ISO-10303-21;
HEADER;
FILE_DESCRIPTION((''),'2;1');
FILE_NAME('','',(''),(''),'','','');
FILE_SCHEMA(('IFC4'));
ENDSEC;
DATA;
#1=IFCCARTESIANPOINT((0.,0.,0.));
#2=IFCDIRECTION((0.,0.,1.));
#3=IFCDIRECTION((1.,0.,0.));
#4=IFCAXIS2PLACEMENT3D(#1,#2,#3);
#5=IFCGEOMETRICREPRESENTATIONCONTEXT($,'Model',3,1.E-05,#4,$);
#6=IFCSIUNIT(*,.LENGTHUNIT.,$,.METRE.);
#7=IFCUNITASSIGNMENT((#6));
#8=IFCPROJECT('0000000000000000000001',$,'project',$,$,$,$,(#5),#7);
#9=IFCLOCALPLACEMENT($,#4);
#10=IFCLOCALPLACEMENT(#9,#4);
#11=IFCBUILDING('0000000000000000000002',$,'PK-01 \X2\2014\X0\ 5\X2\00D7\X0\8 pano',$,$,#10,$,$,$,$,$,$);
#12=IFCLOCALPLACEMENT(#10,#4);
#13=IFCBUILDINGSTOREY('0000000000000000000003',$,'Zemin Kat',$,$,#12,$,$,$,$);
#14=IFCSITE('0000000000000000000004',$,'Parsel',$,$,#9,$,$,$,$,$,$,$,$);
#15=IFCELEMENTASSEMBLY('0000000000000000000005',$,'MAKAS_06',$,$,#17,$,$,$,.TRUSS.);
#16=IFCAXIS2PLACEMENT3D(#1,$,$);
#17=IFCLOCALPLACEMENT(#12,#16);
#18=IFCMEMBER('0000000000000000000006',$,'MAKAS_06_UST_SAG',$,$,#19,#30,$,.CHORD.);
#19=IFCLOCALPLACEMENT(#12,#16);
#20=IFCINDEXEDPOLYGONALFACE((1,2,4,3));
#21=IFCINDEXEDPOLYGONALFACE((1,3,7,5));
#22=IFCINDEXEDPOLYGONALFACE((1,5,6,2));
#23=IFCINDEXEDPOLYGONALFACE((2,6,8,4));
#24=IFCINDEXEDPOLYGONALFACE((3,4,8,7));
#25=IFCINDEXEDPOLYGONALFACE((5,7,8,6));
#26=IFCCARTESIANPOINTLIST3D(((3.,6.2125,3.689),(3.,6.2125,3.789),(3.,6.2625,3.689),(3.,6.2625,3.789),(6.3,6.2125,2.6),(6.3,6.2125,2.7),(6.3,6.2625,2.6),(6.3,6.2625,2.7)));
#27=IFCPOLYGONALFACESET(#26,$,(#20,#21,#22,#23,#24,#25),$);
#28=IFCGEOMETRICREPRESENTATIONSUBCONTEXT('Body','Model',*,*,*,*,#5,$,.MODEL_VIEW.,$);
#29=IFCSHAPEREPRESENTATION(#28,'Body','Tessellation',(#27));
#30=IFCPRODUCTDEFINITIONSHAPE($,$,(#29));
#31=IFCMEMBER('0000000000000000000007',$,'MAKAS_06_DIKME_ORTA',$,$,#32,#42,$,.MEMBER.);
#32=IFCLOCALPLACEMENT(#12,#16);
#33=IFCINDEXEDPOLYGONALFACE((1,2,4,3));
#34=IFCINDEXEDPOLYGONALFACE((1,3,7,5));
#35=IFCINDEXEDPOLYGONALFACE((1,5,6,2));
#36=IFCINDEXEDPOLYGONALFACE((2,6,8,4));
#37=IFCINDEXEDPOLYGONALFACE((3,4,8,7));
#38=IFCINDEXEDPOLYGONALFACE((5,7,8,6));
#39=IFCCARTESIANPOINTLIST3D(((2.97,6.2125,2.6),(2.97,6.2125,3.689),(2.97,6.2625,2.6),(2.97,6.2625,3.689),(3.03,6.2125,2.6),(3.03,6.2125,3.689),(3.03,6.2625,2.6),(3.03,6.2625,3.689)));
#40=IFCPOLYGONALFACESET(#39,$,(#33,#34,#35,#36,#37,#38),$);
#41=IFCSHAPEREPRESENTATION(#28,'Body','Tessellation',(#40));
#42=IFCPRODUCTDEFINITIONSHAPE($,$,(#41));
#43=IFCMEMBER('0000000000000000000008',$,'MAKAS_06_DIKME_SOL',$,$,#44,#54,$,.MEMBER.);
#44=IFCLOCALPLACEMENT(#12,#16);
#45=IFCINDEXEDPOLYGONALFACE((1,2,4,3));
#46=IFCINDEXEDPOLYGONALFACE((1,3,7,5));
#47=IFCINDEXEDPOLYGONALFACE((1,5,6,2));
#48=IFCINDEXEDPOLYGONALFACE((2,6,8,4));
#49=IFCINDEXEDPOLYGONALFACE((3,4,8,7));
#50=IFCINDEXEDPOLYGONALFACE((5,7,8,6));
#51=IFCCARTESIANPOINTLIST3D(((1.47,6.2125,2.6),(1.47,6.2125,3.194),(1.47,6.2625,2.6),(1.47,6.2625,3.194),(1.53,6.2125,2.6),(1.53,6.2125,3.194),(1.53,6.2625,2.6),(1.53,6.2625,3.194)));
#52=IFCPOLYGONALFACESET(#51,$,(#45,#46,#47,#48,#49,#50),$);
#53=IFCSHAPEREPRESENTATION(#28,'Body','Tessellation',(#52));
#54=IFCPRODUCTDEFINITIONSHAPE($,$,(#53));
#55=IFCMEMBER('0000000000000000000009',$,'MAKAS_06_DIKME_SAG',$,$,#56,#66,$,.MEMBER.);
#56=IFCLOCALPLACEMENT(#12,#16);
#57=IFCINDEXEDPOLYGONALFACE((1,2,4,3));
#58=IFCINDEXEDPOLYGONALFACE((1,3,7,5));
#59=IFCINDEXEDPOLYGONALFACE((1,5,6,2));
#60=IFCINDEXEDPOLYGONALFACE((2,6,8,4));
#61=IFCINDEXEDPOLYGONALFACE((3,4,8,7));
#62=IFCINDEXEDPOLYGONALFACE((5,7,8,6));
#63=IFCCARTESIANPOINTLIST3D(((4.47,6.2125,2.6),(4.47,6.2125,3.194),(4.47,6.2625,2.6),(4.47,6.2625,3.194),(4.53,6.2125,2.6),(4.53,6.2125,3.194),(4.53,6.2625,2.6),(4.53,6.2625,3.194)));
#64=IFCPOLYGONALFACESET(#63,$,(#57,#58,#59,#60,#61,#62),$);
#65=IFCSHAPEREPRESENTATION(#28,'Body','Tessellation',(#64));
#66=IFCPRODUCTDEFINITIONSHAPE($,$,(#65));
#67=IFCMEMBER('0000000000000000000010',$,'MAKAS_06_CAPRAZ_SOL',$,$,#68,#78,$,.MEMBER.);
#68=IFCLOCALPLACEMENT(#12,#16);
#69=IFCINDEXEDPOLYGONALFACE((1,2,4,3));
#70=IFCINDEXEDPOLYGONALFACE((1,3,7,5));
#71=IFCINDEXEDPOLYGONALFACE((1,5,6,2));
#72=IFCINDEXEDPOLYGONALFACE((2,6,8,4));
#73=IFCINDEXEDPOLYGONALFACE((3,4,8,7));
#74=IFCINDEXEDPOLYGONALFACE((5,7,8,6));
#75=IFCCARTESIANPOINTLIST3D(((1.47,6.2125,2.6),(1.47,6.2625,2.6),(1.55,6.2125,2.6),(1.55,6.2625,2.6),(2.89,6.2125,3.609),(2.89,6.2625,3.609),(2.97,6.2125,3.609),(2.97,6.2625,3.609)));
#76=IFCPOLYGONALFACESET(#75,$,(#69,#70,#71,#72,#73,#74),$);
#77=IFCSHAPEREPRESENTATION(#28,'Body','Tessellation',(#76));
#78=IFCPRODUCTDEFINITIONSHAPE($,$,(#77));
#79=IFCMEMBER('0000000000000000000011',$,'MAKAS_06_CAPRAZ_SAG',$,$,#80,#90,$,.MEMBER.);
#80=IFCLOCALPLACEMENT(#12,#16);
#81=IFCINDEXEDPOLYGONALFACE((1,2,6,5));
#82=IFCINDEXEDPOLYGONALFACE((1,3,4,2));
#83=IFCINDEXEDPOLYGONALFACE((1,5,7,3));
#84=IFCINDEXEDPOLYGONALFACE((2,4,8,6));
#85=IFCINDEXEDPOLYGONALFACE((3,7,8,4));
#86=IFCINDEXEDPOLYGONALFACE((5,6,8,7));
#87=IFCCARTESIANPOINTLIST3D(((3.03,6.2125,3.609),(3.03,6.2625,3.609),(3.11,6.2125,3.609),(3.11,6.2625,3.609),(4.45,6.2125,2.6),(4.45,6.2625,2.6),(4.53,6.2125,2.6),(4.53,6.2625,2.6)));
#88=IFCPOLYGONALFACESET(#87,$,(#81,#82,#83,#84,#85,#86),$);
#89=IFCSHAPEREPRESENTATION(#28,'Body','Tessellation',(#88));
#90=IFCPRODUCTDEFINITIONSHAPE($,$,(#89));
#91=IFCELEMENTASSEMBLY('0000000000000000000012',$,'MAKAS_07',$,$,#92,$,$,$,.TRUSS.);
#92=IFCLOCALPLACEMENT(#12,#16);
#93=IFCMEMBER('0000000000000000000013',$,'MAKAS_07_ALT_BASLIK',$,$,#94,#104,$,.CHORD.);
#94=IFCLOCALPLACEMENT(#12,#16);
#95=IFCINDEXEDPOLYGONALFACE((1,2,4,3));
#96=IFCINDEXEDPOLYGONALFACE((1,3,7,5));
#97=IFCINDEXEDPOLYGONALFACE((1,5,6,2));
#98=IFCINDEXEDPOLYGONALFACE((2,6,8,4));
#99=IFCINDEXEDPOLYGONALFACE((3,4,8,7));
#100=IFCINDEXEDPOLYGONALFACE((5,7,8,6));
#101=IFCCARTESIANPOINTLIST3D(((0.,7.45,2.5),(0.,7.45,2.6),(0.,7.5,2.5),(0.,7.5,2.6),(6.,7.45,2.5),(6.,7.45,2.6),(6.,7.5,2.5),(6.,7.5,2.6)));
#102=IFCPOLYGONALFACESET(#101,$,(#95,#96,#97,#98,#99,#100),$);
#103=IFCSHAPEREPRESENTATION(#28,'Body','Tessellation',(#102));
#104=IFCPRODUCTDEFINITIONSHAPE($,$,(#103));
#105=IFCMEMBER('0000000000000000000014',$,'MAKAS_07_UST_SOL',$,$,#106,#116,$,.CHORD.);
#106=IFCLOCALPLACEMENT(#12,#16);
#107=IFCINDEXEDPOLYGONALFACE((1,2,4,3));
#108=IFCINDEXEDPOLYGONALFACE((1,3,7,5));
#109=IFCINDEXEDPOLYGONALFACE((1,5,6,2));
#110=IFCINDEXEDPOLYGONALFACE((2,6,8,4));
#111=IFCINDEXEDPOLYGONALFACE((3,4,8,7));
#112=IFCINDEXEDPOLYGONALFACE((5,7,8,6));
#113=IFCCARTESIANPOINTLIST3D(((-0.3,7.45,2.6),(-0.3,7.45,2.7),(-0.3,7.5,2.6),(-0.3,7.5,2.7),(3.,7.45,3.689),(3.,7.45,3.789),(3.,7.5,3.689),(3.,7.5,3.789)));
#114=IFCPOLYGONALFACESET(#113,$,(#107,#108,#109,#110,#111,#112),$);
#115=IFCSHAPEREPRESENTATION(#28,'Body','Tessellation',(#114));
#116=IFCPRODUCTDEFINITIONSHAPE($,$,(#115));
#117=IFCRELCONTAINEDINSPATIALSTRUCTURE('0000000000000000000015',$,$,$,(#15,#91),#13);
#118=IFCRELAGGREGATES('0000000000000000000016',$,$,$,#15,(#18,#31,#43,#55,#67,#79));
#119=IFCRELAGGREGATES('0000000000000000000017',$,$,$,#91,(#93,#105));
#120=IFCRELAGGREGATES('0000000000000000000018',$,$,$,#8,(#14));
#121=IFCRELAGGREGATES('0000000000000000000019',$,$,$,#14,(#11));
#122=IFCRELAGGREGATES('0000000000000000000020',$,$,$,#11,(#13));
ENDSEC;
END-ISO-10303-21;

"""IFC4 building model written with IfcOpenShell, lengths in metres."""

from ifc_helpers import new_model, si_unit, frame, origin_with_axes, place, context, subcontext, project, spatial, line, indexed_curve, outline, extrude, element, aggregate, save


model = new_model("IFC4")

# Units and contexts
model_context = context("Model", 3, precision=1e-05, world=origin_with_axes())
body_context = subcontext(model_context, "Body", "Model", "MODEL_VIEW")
ifc_project = project(units=[si_unit("LENGTHUNIT", "METRE")], contexts=[model_context])

# Site, building, storey
site_placement = place(None, origin_with_axes())
site = spatial("IfcSite", under=ifc_project, at=site_placement, Name="Parsel")
building_placement = place(site_placement, origin_with_axes())
building = spatial("IfcBuilding", under=site, at=building_placement, Name="PK-01 — 5×8 pano")
storey_placement = place(building_placement, origin_with_axes())
storey = spatial("IfcBuildingStorey", under=building, at=storey_placement, Name="Zemin Kat")

# Element assemblies, members
assembly_1_placement = place(storey_placement, origin_with_axes())
assembly_1 = element("IfcElementAssembly", 1, at=assembly_1_placement, inside=storey, Name="MAKAS_06", PredefinedType="TRUSS")
member_1_placement = place(assembly_1_placement, origin_with_axes())
member_1 = element("IfcMember", 2, at=member_1_placement, Name="MAKAS_06_UST_SAG", PredefinedType="CHORD", context=body_context, shape_type="SweptSolid", body=[
    extrude(outline(indexed_curve([(3.0, 3.689), (6.3, 2.6), (6.3, 2.7), (3.0, 3.789)], segments=[line(1, 2, 3, 4, 1)])), frame((0.0, 6.2625, 0.0), z_axis=(0.0, -1.0, 0.0), x_axis=(1.0, 0.0, 0.0)), (0.0, 0.0, 1.0), 0.05),
])
member_2_placement = place(assembly_1_placement, origin_with_axes())
member_2 = element("IfcMember", 3, at=member_2_placement, Name="MAKAS_06_DIKME_ORTA", PredefinedType="MEMBER", context=body_context, shape_type="SweptSolid", body=[
    extrude(outline(indexed_curve([(2.97, 2.6), (3.03, 2.6), (3.03, 3.689), (2.97, 3.689)], segments=[line(1, 2, 3, 4, 1)])), frame((0.0, 6.2625, 0.0), z_axis=(0.0, -1.0, 0.0), x_axis=(1.0, 0.0, 0.0)), (0.0, 0.0, 1.0), 0.05),
])
member_3_placement = place(assembly_1_placement, origin_with_axes())
member_3 = element("IfcMember", 4, at=member_3_placement, Name="MAKAS_06_DIKME_SOL", PredefinedType="MEMBER", context=body_context, shape_type="SweptSolid", body=[
    extrude(outline(indexed_curve([(1.47, 2.6), (1.53, 2.6), (1.53, 3.194), (1.47, 3.194)], segments=[line(1, 2, 3, 4, 1)])), frame((0.0, 6.2625, 0.0), z_axis=(0.0, -1.0, 0.0), x_axis=(1.0, 0.0, 0.0)), (0.0, 0.0, 1.0), 0.05),
])
member_4_placement = place(assembly_1_placement, origin_with_axes())
member_4 = element("IfcMember", 5, at=member_4_placement, Name="MAKAS_06_DIKME_SAG", PredefinedType="MEMBER", context=body_context, shape_type="SweptSolid", body=[
    extrude(outline(indexed_curve([(4.47, 2.6), (4.53, 2.6), (4.53, 3.194), (4.47, 3.194)], segments=[line(1, 2, 3, 4, 1)])), frame((0.0, 6.2625, 0.0), z_axis=(0.0, -1.0, 0.0), x_axis=(1.0, 0.0, 0.0)), (0.0, 0.0, 1.0), 0.05),
])
member_5_placement = place(assembly_1_placement, origin_with_axes())
member_5 = element("IfcMember", 6, at=member_5_placement, Name="MAKAS_06_CAPRAZ_SOL", PredefinedType="MEMBER", context=body_context, shape_type="SweptSolid", body=[
    extrude(outline(indexed_curve([(1.47, 2.6), (1.55, 2.6), (2.97, 3.609), (2.89, 3.609)], segments=[line(1, 2, 3, 4, 1)])), frame((0.0, 6.2625, 0.0), z_axis=(0.0, -1.0, 0.0), x_axis=(1.0, 0.0, 0.0)), (0.0, 0.0, 1.0), 0.05),
])
member_6_placement = place(assembly_1_placement, origin_with_axes())
member_6 = element("IfcMember", 7, at=member_6_placement, Name="MAKAS_06_CAPRAZ_SAG", PredefinedType="MEMBER", context=body_context, shape_type="SweptSolid", body=[
    extrude(outline(indexed_curve([(4.45, 2.6), (4.53, 2.6), (3.11, 3.609), (3.03, 3.609)], segments=[line(1, 2, 3, 4, 1)])), frame((0.0, 6.2625, 0.0), z_axis=(0.0, -1.0, 0.0), x_axis=(1.0, 0.0, 0.0)), (0.0, 0.0, 1.0), 0.05),
])
aggregate(assembly_1, [member_1, member_2, member_3, member_4, member_5, member_6])
assembly_2_placement = place(storey_placement, origin_with_axes())
assembly_2 = element("IfcElementAssembly", 8, at=assembly_2_placement, inside=storey, Name="MAKAS_07", PredefinedType="TRUSS")
member_7_placement = place(assembly_2_placement, origin_with_axes())
member_7 = element("IfcMember", 9, at=member_7_placement, Name="MAKAS_07_ALT_BASLIK", PredefinedType="CHORD", context=body_context, shape_type="SweptSolid", body=[
    extrude(outline(indexed_curve([(0.0, 2.5), (6.0, 2.5), (6.0, 2.6), (0.0, 2.6)], segments=[line(1, 2, 3, 4, 1)])), frame((0.0, 7.5, 0.0), z_axis=(0.0, -1.0, 0.0), x_axis=(1.0, 0.0, 0.0)), (0.0, 0.0, 1.0), 0.05),
])
member_8_placement = place(assembly_2_placement, origin_with_axes())
member_8 = element("IfcMember", 10, at=member_8_placement, Name="MAKAS_07_UST_SOL", PredefinedType="CHORD", context=body_context, shape_type="SweptSolid", body=[
    extrude(outline(indexed_curve([(-0.3, 2.6), (3.0, 3.689), (3.0, 3.789), (-0.3, 2.7)], segments=[line(1, 2, 3, 4, 1)])), frame((0.0, 7.5, 0.0), z_axis=(0.0, -1.0, 0.0), x_axis=(1.0, 0.0, 0.0)), (0.0, 0.0, 1.0), 0.05),
])
aggregate(assembly_2, [member_7, member_8])

save(model, "model.ifc")
